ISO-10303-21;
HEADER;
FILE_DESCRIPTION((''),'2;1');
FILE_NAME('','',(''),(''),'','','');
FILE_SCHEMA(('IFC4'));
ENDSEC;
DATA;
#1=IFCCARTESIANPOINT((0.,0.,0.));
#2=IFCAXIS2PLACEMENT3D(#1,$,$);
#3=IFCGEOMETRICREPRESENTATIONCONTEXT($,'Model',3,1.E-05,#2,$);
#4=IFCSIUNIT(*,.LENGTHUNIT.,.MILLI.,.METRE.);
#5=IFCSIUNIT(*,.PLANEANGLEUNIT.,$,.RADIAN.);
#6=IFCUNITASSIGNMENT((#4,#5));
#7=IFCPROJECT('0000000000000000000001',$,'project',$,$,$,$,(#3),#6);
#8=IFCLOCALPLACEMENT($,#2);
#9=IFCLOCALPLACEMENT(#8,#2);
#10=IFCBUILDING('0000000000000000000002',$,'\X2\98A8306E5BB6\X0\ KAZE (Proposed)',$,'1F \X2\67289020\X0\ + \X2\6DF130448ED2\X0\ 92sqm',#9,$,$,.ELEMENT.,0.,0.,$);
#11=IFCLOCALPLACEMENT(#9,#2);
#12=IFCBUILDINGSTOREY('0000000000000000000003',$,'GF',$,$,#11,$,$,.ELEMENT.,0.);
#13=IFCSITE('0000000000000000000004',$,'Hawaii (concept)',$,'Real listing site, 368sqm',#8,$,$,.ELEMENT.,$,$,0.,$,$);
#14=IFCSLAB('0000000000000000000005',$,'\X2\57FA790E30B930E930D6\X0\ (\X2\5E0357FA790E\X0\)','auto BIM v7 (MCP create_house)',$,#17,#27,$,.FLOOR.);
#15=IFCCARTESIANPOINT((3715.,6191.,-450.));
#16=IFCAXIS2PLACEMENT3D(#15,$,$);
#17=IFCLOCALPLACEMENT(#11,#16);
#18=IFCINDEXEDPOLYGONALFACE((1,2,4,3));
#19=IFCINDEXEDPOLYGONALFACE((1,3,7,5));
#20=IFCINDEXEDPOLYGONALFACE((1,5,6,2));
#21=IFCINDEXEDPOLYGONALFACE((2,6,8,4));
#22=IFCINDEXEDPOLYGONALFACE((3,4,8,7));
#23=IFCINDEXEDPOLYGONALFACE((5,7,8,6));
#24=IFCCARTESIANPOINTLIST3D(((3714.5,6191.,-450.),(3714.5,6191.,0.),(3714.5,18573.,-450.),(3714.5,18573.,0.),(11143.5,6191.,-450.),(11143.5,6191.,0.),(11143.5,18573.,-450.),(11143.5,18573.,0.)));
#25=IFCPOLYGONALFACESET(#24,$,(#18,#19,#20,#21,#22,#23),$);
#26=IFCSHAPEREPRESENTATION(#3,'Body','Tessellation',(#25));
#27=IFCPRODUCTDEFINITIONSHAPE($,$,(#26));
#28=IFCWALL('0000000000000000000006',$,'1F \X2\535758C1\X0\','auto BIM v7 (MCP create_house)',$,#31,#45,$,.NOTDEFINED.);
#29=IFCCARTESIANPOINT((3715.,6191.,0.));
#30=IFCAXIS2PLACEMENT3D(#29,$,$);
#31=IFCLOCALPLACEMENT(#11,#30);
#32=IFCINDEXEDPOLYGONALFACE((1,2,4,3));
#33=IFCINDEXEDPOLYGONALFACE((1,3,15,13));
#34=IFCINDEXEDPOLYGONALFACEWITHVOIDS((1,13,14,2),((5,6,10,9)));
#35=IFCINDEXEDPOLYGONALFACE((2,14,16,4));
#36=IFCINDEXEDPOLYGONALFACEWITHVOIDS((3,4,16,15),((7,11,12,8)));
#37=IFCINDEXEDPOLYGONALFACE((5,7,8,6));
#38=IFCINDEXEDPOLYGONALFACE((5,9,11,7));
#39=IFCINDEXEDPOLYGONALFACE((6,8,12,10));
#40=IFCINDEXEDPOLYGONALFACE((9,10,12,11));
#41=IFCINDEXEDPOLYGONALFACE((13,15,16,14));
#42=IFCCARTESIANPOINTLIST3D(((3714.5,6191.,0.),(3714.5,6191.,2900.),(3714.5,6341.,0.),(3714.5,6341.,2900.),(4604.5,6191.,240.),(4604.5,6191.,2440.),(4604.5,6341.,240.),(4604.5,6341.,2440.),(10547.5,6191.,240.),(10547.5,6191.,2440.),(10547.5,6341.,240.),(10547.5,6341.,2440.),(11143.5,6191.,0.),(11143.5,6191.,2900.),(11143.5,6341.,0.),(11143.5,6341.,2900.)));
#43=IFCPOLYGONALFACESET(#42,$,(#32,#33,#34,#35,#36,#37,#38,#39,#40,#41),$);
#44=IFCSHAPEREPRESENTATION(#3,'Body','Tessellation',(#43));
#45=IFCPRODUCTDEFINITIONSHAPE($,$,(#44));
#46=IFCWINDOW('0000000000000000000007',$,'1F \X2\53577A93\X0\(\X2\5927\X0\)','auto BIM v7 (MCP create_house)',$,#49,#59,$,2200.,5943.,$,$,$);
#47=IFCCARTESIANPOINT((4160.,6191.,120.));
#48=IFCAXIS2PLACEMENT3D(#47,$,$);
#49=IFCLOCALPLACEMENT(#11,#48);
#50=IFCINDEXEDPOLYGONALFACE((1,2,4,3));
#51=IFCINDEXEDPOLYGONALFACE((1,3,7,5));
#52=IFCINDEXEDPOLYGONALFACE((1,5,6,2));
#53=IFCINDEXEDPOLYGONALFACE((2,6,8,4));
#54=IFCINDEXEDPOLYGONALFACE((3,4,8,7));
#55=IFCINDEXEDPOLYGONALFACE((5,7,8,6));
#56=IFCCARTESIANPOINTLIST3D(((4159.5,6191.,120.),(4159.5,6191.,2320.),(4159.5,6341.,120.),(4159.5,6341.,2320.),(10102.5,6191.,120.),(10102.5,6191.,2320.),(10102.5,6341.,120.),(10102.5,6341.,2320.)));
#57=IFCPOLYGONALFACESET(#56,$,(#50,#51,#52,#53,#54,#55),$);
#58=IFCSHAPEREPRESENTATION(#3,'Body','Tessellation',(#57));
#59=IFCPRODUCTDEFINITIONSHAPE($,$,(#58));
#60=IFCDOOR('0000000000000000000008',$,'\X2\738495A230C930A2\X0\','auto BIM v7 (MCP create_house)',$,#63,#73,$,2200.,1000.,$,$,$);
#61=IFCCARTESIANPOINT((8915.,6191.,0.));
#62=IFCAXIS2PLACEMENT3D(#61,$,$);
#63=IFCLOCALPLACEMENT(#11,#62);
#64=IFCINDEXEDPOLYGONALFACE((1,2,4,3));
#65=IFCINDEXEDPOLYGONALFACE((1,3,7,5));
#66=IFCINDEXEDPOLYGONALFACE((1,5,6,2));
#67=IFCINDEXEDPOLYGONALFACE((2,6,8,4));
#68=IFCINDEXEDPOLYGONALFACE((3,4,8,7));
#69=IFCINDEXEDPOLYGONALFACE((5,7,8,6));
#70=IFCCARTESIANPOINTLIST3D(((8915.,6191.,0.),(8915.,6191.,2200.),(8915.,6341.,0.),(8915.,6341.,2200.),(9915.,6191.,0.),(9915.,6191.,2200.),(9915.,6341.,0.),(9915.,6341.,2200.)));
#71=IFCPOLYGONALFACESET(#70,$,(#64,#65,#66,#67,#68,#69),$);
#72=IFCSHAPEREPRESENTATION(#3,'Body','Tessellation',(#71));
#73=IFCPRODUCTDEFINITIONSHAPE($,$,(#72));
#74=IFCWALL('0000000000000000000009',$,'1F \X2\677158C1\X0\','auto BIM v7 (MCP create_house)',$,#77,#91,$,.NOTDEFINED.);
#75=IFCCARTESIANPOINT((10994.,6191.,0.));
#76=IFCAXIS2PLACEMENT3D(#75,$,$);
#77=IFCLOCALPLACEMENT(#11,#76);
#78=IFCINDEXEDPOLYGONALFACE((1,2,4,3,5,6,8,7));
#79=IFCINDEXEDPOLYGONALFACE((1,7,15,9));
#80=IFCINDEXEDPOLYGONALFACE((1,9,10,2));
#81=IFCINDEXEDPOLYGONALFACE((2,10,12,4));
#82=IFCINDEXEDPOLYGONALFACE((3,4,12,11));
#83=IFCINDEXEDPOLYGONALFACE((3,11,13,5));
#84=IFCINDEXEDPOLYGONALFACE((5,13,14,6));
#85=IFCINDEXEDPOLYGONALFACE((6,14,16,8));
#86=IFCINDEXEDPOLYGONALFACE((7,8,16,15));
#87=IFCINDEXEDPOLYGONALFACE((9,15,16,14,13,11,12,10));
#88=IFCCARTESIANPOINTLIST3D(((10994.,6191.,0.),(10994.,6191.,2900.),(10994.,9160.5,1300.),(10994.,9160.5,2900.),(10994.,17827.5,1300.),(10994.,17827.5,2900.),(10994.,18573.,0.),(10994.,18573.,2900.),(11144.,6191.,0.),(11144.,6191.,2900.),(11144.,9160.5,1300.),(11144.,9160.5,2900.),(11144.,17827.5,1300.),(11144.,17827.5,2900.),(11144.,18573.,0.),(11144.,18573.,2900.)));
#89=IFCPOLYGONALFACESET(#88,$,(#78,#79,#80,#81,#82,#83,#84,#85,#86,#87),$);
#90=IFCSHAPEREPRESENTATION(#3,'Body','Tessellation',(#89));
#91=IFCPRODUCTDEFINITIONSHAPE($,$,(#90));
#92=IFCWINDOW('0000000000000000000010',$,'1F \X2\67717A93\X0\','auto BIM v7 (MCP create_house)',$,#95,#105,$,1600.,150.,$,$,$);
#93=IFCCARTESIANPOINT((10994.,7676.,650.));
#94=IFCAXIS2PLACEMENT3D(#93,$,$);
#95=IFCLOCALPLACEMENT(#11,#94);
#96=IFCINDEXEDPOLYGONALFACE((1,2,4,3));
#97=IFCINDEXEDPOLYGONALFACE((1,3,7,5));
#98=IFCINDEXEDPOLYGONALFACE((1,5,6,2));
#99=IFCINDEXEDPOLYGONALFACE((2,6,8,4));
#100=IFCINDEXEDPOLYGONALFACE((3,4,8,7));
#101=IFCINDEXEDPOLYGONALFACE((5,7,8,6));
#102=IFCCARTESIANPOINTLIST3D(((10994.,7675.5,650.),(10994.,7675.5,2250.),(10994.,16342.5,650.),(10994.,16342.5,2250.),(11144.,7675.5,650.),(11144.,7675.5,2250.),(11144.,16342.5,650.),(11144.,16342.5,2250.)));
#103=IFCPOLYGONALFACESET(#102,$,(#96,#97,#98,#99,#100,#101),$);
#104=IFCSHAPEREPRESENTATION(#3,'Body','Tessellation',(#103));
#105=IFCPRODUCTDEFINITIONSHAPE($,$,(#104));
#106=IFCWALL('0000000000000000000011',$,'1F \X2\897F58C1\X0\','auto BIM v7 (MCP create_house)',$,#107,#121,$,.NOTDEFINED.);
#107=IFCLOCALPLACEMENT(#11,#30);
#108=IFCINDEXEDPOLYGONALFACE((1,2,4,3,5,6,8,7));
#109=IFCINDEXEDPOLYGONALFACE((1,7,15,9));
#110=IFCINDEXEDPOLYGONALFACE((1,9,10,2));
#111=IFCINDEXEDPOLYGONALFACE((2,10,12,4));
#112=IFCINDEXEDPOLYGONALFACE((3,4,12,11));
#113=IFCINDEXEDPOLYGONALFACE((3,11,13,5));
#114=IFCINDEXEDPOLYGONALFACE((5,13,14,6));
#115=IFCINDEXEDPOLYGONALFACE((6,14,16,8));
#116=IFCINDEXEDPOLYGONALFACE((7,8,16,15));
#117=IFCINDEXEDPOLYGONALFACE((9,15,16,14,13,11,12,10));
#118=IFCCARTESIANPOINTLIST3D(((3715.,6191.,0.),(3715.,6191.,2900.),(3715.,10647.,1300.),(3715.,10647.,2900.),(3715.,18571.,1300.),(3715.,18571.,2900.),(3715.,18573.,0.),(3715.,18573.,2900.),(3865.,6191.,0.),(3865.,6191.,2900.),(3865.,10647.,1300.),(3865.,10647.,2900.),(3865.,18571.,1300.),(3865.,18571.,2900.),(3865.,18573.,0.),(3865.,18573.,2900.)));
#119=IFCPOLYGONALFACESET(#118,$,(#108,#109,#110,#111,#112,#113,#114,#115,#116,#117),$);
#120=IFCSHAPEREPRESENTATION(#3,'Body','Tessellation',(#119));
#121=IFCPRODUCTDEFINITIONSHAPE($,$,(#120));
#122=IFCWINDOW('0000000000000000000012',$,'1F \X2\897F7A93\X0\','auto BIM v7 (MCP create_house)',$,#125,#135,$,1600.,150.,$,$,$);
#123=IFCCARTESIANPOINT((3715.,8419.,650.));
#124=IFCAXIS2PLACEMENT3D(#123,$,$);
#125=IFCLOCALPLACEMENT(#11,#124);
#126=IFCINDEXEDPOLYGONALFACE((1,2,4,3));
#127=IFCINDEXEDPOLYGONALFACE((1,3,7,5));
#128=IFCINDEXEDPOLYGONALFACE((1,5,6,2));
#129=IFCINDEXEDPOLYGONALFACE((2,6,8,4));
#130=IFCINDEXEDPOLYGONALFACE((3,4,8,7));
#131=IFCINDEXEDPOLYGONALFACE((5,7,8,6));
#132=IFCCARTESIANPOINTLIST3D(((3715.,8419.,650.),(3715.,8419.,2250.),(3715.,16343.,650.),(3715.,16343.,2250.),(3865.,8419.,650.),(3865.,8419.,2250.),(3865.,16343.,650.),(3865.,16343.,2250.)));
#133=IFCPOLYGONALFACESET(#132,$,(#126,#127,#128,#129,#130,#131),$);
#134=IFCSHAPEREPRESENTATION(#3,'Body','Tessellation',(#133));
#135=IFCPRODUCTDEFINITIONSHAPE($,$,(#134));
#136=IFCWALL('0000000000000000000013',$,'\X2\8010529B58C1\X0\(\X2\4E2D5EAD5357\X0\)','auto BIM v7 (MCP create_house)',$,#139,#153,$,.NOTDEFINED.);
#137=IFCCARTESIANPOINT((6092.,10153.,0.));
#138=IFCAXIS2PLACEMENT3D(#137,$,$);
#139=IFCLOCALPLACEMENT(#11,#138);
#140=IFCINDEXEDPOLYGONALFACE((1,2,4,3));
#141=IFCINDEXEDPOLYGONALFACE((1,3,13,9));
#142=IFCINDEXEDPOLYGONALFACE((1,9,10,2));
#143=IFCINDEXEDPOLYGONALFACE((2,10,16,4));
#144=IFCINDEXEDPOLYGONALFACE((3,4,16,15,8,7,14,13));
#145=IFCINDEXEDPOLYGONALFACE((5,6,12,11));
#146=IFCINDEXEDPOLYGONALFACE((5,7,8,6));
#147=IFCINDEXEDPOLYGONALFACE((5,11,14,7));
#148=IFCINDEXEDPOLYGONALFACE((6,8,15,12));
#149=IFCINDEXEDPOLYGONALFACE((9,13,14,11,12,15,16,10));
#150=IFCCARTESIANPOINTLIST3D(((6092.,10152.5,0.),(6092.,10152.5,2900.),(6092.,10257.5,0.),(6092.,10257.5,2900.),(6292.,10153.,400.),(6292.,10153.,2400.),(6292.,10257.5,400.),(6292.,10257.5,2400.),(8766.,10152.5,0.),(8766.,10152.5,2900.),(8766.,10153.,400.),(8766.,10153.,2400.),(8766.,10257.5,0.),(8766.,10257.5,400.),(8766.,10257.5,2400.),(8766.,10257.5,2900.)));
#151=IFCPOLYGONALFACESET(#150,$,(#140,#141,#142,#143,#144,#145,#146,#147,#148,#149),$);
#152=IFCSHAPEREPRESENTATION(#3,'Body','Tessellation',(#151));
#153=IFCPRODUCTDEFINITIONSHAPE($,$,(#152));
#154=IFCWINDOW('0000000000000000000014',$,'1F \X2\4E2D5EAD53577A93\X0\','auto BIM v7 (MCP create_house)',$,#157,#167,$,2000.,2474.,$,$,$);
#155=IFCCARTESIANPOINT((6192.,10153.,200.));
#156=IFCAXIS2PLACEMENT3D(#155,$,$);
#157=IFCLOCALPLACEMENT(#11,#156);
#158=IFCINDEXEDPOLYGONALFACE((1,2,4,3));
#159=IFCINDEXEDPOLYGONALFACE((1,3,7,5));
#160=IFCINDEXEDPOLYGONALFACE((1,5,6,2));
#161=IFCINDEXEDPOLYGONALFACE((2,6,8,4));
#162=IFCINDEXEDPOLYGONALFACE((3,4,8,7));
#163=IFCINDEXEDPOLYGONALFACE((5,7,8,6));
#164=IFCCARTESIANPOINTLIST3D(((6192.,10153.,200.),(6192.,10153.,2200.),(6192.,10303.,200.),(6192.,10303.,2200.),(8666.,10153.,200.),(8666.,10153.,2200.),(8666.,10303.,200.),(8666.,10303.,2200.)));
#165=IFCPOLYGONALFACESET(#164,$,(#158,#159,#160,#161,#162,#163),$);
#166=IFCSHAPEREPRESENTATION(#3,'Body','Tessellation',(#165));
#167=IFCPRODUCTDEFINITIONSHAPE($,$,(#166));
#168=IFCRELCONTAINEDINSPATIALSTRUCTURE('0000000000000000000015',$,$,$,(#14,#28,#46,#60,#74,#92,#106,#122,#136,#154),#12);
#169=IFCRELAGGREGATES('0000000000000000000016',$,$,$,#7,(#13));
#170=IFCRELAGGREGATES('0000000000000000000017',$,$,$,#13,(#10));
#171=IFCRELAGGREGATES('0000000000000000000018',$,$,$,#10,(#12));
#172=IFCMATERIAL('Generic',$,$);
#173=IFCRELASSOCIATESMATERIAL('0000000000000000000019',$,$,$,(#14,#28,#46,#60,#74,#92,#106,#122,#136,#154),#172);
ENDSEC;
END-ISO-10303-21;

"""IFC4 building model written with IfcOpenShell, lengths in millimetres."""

from ifc_helpers import new_model, si_unit, frame, frame_2d, origin, place, context, project, spatial, rectangle, extrude, material, element, fill, save


model = new_model("IFC4")

# Units and contexts
model_context = context("Model", 3, precision=1e-05, world=origin())
ifc_project = project(units=[si_unit("LENGTHUNIT", "METRE", prefix="MILLI"), si_unit("PLANEANGLEUNIT", "RADIAN")], contexts=[model_context])

# Site, building, storey
site_placement = place(None, origin())
site = spatial("IfcSite", under=ifc_project, at=site_placement, Name="Hawaii (concept)", ObjectType="Real listing site, 368sqm", CompositionType="ELEMENT", RefElevation=0.0)
building_placement = place(site_placement, origin())
building = spatial("IfcBuilding", under=site, at=building_placement, Name="風の家 KAZE (Proposed)", ObjectType="1F 木造 + 深い軒 92sqm", CompositionType="ELEMENT", ElevationOfRefHeight=0.0, ElevationOfTerrain=0.0)
storey_placement = place(building_placement, origin())
storey = spatial("IfcBuildingStorey", under=building, at=storey_placement, Name="GF", CompositionType="ELEMENT", Elevation=0.0)

# Slab
ifc_material = material(Name="Generic")
slab_1_placement = place(storey_placement, frame((3715.0, 6191.0, -450.0)))
element("IfcSlab", 1, at=slab_1_placement, inside=storey, material=ifc_material, Name="基礎スラブ (布基礎)", Description="auto BIM v7 (MCP create_house)", PredefinedType="FLOOR", context=model_context, shape_type="SweptSolid", body=[
    extrude(rectangle(XDim=7429.0, YDim=12382.0, at=frame_2d((3714.0, 6191.0))), frame((3715.0, 6191.0, -450.0)), (0.0, 0.0, 1.0), 450.0),
])

# Wall, openings, window, door
wall_1_placement = place(storey_placement, frame((3715.0, 6191.0, 0.0)))
wall_1 = element("IfcWall", 2, at=wall_1_placement, inside=storey, material=ifc_material, Name="1F 南壁", Description="auto BIM v7 (MCP create_house)", PredefinedType="NOTDEFINED", context=model_context, shape_type="SweptSolid", body=[
    extrude(rectangle(XDim=7429.0, YDim=150.0, at=frame_2d((3714.0, 75.0))), frame((3715.0, 6191.0, 0.0)), (0.0, 0.0, 1.0), 2900.0),
])
opening_1_placement = place(storey_placement, frame((4160.0, 6191.0, 120.0)))
opening_1 = element("IfcOpeningElement", 3, at=opening_1_placement, cuts=wall_1, PredefinedType="NOTDEFINED", context=model_context, shape_type="SweptSolid", body=[
    extrude(rectangle(XDim=5943.0, YDim=150.0, at=frame_2d((2971.0, 75.0))), frame((4160.0, 6191.0, 120.0)), (0.0, 0.0, 1.0), 2200.0),
])
opening_2_placement = place(storey_placement, frame((8915.0, 6191.0, 0.0)))
opening_2 = element("IfcOpeningElement", 4, at=opening_2_placement, cuts=wall_1, PredefinedType="NOTDEFINED", context=model_context, shape_type="SweptSolid", body=[
    extrude(rectangle(XDim=1000.0, YDim=150.0, at=frame_2d((500.0, 75.0))), frame((8915.0, 6191.0, 0.0)), (0.0, 0.0, 1.0), 2200.0),
])
window_1_placement = place(storey_placement, frame((4160.0, 6191.0, 120.0)))
window_1 = element("IfcWindow", 5, at=window_1_placement, inside=storey, material=ifc_material, Name="1F 南窓(大)", Description="auto BIM v7 (MCP create_house)", OverallHeight=2200.0, OverallWidth=5943.0, context=model_context, shape_type="SweptSolid", body=[
    extrude(rectangle(XDim=5943.0, YDim=150.0, at=frame_2d((2971.0, 75.0))), frame((4160.0, 6191.0, 120.0)), (0.0, 0.0, 1.0), 2200.0),
])
fill(opening_1, window_1)
door_placement = place(storey_placement, frame((8915.0, 6191.0, 0.0)))
door = element("IfcDoor", 6, at=door_placement, inside=storey, material=ifc_material, Name="玄関ドア", Description="auto BIM v7 (MCP create_house)", OverallHeight=2200.0, OverallWidth=1000.0, context=model_context, shape_type="SweptSolid", body=[
    extrude(rectangle(XDim=1000.0, YDim=150.0, at=frame_2d((500.0, 75.0))), frame((8915.0, 6191.0, 0.0)), (0.0, 0.0, 1.0), 2200.0),
])
fill(opening_2, door)

# Walls, openings, windows
wall_2_placement = place(storey_placement, frame((10994.0, 6191.0, 0.0)))
wall_2 = element("IfcWall", 7, at=wall_2_placement, inside=storey, material=ifc_material, Name="1F 東壁", Description="auto BIM v7 (MCP create_house)", PredefinedType="NOTDEFINED", context=model_context, shape_type="SweptSolid", body=[
    extrude(rectangle(XDim=150.0, YDim=12382.0, at=frame_2d((75.0, 6191.0))), frame((10994.0, 6191.0, 0.0)), (0.0, 0.0, 1.0), 2900.0),
])
opening_3_placement = place(storey_placement, frame((10994.0, 7676.0, 650.0)))
opening_3 = element("IfcOpeningElement", 8, at=opening_3_placement, cuts=wall_2, PredefinedType="NOTDEFINED", context=model_context, shape_type="SweptSolid", body=[
    extrude(rectangle(XDim=150.0, YDim=8667.0, at=frame_2d((75.0, 4333.0))), frame((10994.0, 7676.0, 650.0)), (0.0, 0.0, 1.0), 1600.0),
])
window_2_placement = place(storey_placement, frame((10994.0, 7676.0, 650.0)))
window_2 = element("IfcWindow", 9, at=window_2_placement, inside=storey, material=ifc_material, Name="1F 東窓", Description="auto BIM v7 (MCP create_house)", OverallHeight=1600.0, OverallWidth=150.0, context=model_context, shape_type="SweptSolid", body=[
    extrude(rectangle(XDim=150.0, YDim=8667.0, at=frame_2d((75.0, 4333.0))), frame((10994.0, 7676.0, 650.0)), (0.0, 0.0, 1.0), 1600.0),
])
fill(opening_3, window_2)
wall_3_placement = place(storey_placement, frame((3715.0, 6191.0, 0.0)))
wall_3 = element("IfcWall", 10, at=wall_3_placement, inside=storey, material=ifc_material, Name="1F 西壁", Description="auto BIM v7 (MCP create_house)", PredefinedType="NOTDEFINED", context=model_context, shape_type="SweptSolid", body=[
    extrude(rectangle(XDim=150.0, YDim=12382.0, at=frame_2d((75.0, 6191.0))), frame((3715.0, 6191.0, 0.0)), (0.0, 0.0, 1.0), 2900.0),
])
opening_4_placement = place(storey_placement, frame((3715.0, 8419.0, 650.0)))
opening_4 = element("IfcOpeningElement", 11, at=opening_4_placement, cuts=wall_3, PredefinedType="NOTDEFINED", context=model_context, shape_type="SweptSolid", body=[
    extrude(rectangle(XDim=150.0, YDim=7924.0, at=frame_2d((75.0, 3962.0))), frame((3715.0, 8419.0, 650.0)), (0.0, 0.0, 1.0), 1600.0),
])
window_3_placement = place(storey_placement, frame((3715.0, 8419.0, 650.0)))
window_3 = element("IfcWindow", 12, at=window_3_placement, inside=storey, material=ifc_material, Name="1F 西窓", Description="auto BIM v7 (MCP create_house)", OverallHeight=1600.0, OverallWidth=150.0, context=model_context, shape_type="SweptSolid", body=[
    extrude(rectangle(XDim=150.0, YDim=7924.0, at=frame_2d((75.0, 3962.0))), frame((3715.0, 8419.0, 650.0)), (0.0, 0.0, 1.0), 1600.0),
])
fill(opening_4, window_3)
wall_4_placement = place(storey_placement, frame((6092.0, 10153.0, 0.0)))
wall_4 = element("IfcWall", 13, at=wall_4_placement, inside=storey, material=ifc_material, Name="耐力壁(中庭南)", Description="auto BIM v7 (MCP create_house)", PredefinedType="NOTDEFINED", context=model_context, shape_type="SweptSolid", body=[
    extrude(rectangle(XDim=2674.0, YDim=105.0, at=frame_2d((1337.0, 52.0))), frame((6092.0, 10153.0, 0.0)), (0.0, 0.0, 1.0), 2900.0),
])
opening_5_placement = place(storey_placement, frame((6192.0, 10153.0, 200.0)))
opening_5 = element("IfcOpeningElement", 14, at=opening_5_placement, cuts=wall_4, PredefinedType="NOTDEFINED", context=model_context, shape_type="SweptSolid", body=[
    extrude(rectangle(XDim=2474.0, YDim=150.0, at=frame_2d((1237.0, 75.0))), frame((6192.0, 10153.0, 200.0)), (0.0, 0.0, 1.0), 2000.0),
])
window_4_placement = place(storey_placement, frame((6192.0, 10153.0, 200.0)))
window_4 = element("IfcWindow", 15, at=window_4_placement, inside=storey, material=ifc_material, Name="1F 中庭南窓", Description="auto BIM v7 (MCP create_house)", OverallHeight=2000.0, OverallWidth=2474.0, context=model_context, shape_type="SweptSolid", body=[
    extrude(rectangle(XDim=2474.0, YDim=150.0, at=frame_2d((1237.0, 75.0))), frame((6192.0, 10153.0, 200.0)), (0.0, 0.0, 1.0), 2000.0),
])
fill(opening_5, window_4)

save(model, "model.ifc")
